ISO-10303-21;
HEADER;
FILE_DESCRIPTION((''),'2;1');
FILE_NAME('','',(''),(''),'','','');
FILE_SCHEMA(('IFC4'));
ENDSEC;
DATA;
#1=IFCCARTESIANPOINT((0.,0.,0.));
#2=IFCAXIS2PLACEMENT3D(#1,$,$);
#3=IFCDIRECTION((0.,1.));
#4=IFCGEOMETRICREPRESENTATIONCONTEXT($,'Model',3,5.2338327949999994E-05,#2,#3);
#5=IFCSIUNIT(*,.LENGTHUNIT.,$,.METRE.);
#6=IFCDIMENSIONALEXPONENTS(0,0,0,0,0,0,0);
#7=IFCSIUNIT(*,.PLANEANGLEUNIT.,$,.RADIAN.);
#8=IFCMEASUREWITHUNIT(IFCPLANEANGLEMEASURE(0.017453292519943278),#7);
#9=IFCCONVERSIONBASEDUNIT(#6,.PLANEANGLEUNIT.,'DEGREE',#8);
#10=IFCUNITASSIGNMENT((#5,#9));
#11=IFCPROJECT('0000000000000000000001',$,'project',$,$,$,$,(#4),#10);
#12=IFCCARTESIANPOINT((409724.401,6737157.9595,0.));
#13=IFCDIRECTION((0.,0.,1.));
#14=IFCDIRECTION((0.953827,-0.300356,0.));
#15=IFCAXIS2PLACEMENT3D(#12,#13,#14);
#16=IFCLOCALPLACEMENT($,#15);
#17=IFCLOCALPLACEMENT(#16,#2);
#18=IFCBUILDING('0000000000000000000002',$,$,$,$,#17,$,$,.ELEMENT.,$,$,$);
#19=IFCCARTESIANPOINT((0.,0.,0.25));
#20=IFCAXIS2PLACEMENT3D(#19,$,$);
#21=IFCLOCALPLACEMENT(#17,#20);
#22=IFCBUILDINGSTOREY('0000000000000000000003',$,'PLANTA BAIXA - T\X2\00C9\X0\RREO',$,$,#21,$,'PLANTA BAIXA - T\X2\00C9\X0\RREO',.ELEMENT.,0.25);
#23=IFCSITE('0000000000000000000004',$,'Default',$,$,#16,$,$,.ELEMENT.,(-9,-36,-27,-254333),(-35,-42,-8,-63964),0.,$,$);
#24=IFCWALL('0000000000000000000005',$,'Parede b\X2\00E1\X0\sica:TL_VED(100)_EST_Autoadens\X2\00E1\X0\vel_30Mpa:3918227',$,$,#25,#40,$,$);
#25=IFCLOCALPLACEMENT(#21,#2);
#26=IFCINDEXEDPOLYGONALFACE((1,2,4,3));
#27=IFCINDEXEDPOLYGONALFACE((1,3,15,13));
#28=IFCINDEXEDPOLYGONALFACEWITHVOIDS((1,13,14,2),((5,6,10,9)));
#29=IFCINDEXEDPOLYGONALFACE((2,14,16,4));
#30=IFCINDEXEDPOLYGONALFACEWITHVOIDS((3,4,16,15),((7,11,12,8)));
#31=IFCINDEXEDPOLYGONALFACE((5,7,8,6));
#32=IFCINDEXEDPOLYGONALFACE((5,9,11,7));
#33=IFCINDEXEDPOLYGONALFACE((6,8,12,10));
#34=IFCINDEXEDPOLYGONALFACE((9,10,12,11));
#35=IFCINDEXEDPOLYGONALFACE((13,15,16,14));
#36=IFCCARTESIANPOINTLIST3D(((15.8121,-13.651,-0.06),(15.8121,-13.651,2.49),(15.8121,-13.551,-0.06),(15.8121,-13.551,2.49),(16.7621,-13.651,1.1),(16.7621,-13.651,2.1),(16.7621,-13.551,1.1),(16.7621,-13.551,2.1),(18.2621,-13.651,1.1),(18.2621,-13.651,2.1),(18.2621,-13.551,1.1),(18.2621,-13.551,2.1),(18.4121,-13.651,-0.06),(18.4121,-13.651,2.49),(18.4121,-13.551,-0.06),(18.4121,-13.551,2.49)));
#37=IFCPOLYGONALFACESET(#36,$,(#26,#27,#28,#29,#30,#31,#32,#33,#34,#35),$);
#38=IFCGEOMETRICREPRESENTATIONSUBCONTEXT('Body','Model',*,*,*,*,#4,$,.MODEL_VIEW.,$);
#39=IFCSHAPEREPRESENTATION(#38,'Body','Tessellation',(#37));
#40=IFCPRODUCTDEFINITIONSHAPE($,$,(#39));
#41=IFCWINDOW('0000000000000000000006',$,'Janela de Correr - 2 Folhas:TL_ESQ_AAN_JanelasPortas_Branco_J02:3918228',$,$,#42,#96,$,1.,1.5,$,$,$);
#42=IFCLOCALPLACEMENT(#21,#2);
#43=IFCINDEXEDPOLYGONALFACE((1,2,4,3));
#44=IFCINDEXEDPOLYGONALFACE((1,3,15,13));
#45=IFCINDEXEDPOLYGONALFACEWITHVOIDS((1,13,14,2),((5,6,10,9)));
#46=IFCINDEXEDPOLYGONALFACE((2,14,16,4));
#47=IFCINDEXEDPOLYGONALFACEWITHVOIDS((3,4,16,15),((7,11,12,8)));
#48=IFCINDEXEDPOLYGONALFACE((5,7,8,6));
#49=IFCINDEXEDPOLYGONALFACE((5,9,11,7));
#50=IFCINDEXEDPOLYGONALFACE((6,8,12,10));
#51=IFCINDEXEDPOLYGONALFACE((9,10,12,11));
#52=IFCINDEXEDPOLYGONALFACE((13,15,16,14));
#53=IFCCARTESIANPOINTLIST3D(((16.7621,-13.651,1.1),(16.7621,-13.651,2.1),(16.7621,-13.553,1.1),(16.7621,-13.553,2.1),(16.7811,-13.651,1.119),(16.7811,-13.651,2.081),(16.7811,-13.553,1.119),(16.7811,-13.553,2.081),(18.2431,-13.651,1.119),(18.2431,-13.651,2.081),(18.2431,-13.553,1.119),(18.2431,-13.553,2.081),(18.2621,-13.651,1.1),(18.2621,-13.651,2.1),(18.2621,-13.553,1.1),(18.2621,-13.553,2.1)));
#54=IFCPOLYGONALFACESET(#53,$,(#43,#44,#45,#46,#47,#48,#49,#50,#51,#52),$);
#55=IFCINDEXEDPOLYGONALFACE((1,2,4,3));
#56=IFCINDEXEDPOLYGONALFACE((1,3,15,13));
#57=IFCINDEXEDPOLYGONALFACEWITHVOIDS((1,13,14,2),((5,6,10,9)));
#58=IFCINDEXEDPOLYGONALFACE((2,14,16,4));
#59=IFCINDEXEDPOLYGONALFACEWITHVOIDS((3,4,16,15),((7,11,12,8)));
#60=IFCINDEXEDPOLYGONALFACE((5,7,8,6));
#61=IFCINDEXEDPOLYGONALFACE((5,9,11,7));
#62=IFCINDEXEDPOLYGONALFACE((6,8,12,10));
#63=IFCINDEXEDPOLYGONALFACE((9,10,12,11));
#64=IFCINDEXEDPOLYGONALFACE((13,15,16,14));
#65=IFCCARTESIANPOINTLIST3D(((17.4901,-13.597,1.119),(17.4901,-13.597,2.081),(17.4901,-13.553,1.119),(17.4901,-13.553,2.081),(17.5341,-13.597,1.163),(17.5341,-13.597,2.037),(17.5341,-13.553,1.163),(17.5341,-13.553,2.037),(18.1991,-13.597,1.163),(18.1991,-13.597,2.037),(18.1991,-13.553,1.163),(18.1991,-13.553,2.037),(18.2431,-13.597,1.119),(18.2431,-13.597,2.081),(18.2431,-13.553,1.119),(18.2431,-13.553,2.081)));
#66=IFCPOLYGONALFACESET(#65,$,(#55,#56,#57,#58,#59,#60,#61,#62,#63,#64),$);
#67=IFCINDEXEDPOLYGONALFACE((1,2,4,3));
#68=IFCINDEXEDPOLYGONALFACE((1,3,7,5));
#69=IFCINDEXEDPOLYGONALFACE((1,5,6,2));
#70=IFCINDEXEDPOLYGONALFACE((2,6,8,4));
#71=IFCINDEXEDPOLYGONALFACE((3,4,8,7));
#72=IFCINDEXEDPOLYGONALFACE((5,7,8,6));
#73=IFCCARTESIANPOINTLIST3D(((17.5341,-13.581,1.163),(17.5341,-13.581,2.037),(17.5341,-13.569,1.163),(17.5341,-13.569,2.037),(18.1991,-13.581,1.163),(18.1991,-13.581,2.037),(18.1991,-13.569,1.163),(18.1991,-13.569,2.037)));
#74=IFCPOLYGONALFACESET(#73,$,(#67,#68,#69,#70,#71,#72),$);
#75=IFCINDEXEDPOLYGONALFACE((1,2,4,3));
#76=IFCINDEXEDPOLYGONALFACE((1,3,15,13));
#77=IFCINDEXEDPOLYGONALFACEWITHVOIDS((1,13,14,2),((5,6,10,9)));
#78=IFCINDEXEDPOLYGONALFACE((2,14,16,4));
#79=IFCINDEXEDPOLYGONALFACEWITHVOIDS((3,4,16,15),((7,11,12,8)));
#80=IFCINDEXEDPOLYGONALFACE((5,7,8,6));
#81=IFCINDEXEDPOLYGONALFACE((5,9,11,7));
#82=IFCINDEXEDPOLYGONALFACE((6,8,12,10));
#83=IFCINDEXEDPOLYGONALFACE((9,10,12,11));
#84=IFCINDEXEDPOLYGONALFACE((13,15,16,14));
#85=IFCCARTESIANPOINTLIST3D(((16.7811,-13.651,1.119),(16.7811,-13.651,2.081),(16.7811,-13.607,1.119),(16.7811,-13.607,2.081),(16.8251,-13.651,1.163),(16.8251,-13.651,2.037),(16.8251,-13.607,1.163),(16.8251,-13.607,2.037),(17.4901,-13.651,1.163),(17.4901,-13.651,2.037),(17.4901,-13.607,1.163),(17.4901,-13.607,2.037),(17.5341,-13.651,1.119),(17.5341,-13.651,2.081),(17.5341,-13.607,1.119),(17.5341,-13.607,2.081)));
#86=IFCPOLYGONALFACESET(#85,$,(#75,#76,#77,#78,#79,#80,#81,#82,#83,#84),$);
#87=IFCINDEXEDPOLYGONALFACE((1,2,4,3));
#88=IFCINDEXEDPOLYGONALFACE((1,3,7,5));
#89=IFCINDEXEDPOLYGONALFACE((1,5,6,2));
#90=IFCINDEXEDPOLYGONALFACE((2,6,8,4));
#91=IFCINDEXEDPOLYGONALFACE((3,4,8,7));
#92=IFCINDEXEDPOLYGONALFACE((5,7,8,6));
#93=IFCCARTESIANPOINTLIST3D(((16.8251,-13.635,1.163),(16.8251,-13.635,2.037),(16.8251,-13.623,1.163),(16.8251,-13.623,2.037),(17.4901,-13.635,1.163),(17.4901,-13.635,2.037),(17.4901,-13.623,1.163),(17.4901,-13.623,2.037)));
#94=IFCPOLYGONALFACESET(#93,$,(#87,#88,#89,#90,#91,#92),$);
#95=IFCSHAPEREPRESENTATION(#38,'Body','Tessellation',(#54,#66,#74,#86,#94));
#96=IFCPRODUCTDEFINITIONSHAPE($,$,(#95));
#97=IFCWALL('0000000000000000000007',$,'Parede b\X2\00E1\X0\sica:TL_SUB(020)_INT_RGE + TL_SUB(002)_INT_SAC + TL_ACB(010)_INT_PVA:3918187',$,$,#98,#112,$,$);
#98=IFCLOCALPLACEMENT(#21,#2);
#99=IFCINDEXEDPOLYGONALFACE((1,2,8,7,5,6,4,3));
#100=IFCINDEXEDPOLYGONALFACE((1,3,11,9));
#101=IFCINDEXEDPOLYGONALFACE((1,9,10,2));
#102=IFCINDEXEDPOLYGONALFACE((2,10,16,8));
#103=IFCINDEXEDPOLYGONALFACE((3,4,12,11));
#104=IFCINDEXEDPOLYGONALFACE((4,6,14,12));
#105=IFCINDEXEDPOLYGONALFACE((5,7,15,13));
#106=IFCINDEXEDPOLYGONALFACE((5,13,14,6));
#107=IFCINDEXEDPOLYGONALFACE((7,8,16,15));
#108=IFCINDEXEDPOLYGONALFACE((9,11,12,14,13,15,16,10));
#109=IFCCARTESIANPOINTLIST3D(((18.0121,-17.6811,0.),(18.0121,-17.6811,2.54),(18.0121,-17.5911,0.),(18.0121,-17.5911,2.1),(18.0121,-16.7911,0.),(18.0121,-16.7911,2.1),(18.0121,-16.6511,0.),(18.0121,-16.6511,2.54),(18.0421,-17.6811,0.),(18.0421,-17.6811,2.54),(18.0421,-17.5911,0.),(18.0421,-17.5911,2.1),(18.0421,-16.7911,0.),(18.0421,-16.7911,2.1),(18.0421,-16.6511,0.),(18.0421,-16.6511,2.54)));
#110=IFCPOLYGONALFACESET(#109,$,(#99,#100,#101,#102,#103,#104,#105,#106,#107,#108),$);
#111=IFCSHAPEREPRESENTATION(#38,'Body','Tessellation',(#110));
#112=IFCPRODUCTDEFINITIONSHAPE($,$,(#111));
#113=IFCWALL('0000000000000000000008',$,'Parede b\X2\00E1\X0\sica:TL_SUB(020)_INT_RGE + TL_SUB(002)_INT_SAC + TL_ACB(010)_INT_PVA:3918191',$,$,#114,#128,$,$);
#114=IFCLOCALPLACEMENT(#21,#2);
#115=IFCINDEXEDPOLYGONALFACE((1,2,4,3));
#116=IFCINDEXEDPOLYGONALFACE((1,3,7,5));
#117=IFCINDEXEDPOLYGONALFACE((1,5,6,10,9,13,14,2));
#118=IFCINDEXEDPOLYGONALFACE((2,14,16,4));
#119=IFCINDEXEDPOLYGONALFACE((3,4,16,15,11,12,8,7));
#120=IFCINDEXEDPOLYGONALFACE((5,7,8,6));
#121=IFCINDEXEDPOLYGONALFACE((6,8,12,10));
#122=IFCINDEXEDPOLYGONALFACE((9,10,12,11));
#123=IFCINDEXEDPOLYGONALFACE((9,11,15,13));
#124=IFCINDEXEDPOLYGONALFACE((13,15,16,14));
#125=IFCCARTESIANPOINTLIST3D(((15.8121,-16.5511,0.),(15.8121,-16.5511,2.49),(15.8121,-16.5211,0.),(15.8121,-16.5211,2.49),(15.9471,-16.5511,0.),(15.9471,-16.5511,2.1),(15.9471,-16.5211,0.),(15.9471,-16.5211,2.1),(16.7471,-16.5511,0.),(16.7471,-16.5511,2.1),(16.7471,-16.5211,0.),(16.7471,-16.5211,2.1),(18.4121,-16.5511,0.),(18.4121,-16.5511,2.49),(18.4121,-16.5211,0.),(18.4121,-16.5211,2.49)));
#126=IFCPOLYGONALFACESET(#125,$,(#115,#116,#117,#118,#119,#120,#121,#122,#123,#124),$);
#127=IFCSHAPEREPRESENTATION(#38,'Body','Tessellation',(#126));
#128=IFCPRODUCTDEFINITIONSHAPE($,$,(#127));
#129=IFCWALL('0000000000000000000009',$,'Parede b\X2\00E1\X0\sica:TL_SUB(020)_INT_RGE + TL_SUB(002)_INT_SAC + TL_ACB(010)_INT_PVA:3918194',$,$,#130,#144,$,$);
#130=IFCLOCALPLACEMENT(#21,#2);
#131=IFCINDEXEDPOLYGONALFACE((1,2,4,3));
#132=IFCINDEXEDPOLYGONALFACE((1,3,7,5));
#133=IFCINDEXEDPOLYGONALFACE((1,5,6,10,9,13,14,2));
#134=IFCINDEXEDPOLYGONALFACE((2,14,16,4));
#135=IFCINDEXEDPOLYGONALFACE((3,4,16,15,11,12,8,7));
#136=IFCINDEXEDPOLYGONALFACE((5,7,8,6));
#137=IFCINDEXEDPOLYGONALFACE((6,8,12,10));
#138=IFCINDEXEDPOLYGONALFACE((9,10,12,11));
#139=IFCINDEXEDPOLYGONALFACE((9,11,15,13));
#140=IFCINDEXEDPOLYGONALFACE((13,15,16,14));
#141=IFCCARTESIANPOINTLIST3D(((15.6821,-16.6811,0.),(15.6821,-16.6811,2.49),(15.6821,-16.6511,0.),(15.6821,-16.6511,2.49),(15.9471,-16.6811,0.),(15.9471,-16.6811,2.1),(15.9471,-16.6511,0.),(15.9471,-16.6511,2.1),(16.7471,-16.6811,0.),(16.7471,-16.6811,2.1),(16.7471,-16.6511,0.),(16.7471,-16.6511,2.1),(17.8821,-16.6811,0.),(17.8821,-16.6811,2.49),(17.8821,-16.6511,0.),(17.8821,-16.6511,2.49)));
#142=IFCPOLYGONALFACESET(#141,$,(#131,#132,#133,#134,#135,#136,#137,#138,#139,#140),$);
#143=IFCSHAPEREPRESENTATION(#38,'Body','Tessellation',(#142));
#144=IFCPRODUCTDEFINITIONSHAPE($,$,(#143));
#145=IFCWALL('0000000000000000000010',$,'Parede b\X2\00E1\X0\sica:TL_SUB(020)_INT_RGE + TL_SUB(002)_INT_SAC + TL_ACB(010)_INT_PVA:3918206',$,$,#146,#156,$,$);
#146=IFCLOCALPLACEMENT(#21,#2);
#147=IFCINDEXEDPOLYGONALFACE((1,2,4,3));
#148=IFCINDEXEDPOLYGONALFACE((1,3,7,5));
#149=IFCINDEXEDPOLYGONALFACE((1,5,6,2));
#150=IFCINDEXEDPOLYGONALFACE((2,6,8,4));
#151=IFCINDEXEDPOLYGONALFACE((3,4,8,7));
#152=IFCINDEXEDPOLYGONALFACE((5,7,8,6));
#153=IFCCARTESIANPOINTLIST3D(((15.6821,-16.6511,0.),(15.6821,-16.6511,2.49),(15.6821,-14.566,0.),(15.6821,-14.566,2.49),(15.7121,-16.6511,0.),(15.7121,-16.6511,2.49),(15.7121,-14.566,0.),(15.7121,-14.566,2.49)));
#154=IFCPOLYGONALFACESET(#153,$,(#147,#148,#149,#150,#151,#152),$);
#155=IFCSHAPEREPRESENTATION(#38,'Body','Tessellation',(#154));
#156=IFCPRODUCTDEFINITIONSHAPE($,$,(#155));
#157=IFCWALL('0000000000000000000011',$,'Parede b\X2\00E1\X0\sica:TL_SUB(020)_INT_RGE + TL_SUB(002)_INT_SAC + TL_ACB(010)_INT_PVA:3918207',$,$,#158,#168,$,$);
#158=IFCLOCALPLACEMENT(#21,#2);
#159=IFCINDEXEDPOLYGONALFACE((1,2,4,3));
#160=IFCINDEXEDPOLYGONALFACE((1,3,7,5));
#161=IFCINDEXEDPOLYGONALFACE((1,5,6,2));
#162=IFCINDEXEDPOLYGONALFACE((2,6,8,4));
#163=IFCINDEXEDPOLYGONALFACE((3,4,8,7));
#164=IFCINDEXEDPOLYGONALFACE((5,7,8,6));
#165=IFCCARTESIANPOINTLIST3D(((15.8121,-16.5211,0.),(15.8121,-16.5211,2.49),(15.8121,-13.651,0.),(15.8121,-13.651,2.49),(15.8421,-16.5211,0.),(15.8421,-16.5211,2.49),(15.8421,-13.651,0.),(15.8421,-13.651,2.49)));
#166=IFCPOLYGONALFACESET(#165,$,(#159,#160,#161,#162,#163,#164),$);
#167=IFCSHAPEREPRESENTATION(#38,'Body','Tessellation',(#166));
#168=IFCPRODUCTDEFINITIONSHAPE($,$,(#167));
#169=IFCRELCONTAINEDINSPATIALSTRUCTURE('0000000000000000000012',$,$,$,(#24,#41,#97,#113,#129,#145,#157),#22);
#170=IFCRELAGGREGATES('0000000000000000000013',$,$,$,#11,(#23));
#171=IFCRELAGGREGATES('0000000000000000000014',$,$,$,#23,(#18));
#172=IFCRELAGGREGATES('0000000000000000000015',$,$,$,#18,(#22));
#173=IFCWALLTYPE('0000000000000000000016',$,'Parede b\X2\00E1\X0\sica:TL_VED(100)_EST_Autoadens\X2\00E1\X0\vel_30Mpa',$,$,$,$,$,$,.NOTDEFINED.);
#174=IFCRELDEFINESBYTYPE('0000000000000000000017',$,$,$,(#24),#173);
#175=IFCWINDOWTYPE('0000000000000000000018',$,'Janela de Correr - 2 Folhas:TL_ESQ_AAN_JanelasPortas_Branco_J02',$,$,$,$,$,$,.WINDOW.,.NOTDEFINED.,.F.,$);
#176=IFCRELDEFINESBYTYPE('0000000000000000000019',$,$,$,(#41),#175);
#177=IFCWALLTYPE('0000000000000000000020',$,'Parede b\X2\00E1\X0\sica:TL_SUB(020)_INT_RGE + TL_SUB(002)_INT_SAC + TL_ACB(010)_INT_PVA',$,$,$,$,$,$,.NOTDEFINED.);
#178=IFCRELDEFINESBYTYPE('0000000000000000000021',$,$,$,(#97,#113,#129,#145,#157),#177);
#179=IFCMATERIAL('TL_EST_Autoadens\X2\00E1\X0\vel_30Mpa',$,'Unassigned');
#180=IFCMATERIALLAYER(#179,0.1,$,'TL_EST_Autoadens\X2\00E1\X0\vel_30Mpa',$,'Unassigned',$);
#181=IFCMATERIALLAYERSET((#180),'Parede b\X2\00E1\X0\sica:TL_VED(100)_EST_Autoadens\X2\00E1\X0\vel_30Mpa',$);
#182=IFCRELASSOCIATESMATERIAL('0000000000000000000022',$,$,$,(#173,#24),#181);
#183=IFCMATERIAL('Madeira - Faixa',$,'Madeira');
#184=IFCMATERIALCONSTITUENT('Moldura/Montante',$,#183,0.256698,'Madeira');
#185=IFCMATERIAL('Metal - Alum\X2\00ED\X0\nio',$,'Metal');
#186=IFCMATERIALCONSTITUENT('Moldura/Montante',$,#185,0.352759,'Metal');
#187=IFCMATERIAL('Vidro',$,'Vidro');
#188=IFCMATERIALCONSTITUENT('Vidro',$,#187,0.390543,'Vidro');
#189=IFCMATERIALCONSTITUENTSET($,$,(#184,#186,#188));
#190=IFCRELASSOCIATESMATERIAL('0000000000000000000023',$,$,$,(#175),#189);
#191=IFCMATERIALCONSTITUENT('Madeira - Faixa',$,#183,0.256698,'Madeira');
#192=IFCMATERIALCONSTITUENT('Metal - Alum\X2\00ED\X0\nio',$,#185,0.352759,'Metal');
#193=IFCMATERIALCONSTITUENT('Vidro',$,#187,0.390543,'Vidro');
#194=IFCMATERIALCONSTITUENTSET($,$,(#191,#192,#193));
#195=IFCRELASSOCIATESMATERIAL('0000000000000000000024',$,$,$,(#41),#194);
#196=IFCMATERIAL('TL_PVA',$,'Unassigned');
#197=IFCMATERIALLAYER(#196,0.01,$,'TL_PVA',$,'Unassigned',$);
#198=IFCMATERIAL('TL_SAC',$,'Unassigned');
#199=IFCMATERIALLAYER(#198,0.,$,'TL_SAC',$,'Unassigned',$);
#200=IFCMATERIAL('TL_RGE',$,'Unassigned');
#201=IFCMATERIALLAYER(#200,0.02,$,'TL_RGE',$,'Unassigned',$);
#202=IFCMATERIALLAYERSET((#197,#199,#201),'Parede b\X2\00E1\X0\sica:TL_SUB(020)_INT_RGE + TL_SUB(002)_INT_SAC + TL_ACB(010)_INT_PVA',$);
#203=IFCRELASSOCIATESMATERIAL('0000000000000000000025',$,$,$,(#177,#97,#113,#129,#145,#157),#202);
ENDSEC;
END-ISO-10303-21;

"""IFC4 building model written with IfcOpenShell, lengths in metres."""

from ifc_helpers import new_model, entity, si_unit, converted_unit, direction, frame, frame_2d, origin, origin_2d_with_axis, place, context, subcontext, project, spatial, polyline, rectangle, outline, extrude, source, transform, mapped, material, layer, layer_set, layer_usage, constituent, constituent_set, type_object, type_shapes, element, fill, save


model = new_model("IFC4")

# Units and contexts
model_context = context("Model", 3, precision=5.2338327949999994e-05, world=origin(), true_north=direction((0.0, 1.0)))
body_context = subcontext(model_context, "Body", "Model", "MODEL_VIEW")
ifc_project = project(units=[si_unit("LENGTHUNIT", "METRE"), converted_unit("PLANEANGLEUNIT", "DEGREE", entity("IfcPlaneAngleMeasure", 0.017453292519943278), si_unit("PLANEANGLEUNIT", "RADIAN"), dimensions=[0, 0, 0, 0, 0, 0, 0])], contexts=[model_context])

# Site, building, storey
site_placement = place(None, frame((409724.401, 6737157.9595, 0.0), z_axis=(0.0, 0.0, 1.0), x_axis=(0.953827, -0.300356, 0.0)))
site = spatial("IfcSite", under=ifc_project, at=site_placement, Name="Default", CompositionType="ELEMENT", RefLatitude=(-9, -36, -27, -254333), RefLongitude=(-35, -42, -8, -63964), RefElevation=0.0)
building_placement = place(site_placement, origin())
building = spatial("IfcBuilding", under=site, at=building_placement, CompositionType="ELEMENT")
storey_placement = place(building_placement, frame((0.0, 0.0, 0.25)))
storey = spatial("IfcBuildingStorey", under=building, at=storey_placement, Name="PLANTA BAIXA - TÉRREO", LongName="PLANTA BAIXA - TÉRREO", CompositionType="ELEMENT", Elevation=0.25)

# Shared definitions
ifc_material_1 = material(Name="TL_EST_Autoadensável_30Mpa", Category="Unassigned")
ifc_layer_1 = layer(ifc_material_1, 0.1, Name="TL_EST_Autoadensável_30Mpa", Category="Unassigned")
ifc_layer_set_1 = layer_set([ifc_layer_1], Name="Parede básica:TL_VED(100)_EST_Autoadensável_30Mpa")
wall_type_1 = type_object("IfcWallType", Name="Parede básica:TL_VED(100)_EST_Autoadensável_30Mpa", PredefinedType="NOTDEFINED", material=ifc_layer_set_1)

# Shared definitions
ifc_material_2 = material(Name="Vidro", Category="Vidro")

# Wall, opening, window
ifc_layer_usage_1 = layer_usage(ifc_layer_set_1, "AXIS2", "POSITIVE", -0.05)
wall_1_placement = place(storey_placement, frame((18.4121, -13.601, -0.06), z_axis=(0.0, 0.0, 1.0), x_axis=(-1.0, 0.0, 0.0)))
wall_1 = element("IfcWall", 1, at=wall_1_placement, inside=storey, type_object=wall_type_1, material=ifc_layer_usage_1, Name="Parede básica:TL_VED(100)_EST_Autoadensável_30Mpa:3918227", context=body_context, shape_type="SweptSolid", body=[
    extrude(rectangle(XDim=2.6, YDim=0.1, at=frame_2d((1.3, 0.0), x_axis=(-1.0, 0.0))), origin(), (0.0, 0.0, 1.0), 2.55),
])
opening_1_placement = place(wall_1_placement, frame((1.65, 0.05, 1.16)))
opening_1 = element("IfcOpeningElement", 2, at=opening_1_placement, cuts=wall_1, PredefinedType="OPENING", context=body_context, shape_type="SweptSolid", body=[
    extrude(rectangle(XDim=1.0, YDim=1.5, at=frame_2d((0.5, 0.75), x_axis=(-1.0, 0.0))), frame((0.0, 0.0, 0.0), z_axis=(0.0, -1.0, 0.0), x_axis=(0.0, 0.0, 1.0)), (0.0, 0.0, 1.0), 0.1),
])
ifc_material_3 = material(Name="Madeira - Faixa", Category="Madeira")
ifc_constituent_1 = constituent(ifc_material_3, Name="Madeira - Faixa", Category="Madeira", fraction=0.256698)
ifc_material_4 = material(Name="Metal - Alumínio", Category="Metal")
ifc_constituent_2 = constituent(ifc_material_4, Name="Metal - Alumínio", Category="Metal", fraction=0.352759)
ifc_constituent_3 = constituent(ifc_material_2, Name="Vidro", Category="Vidro", fraction=0.390543)
ifc_constituent_set_1 = constituent_set(constituents=[ifc_constituent_1, ifc_constituent_2, ifc_constituent_3])
ifc_constituent_4 = constituent(ifc_material_3, Name="Moldura/Montante", Category="Madeira", fraction=0.256698)
ifc_constituent_5 = constituent(ifc_material_4, Name="Moldura/Montante", Category="Metal", fraction=0.352759)
ifc_constituent_6 = constituent(ifc_material_2, Name="Vidro", Category="Vidro", fraction=0.390543)
ifc_constituent_set_2 = constituent_set(constituents=[ifc_constituent_4, ifc_constituent_5, ifc_constituent_6])
window_type = type_object("IfcWindowType", Name="Janela de Correr - 2 Folhas:TL_ESQ_AAN_JanelasPortas_Branco_J02", ParameterTakesPrecedence=False, PartitioningType="NOTDEFINED", PredefinedType="WINDOW", material=ifc_constituent_set_2)
shared_shape_1 = source(origin(), body_context, "Body", "SweptSolid", [
    extrude(outline(polyline([(-0.75, -0.5), (0.75, -0.5), (0.75, 0.5), (-0.75, 0.5), (-0.75, -0.5)]), holes=[polyline([(-0.731, -0.481), (-0.731, 0.481), (0.731, 0.481), (0.731, -0.481), (-0.731, -0.481)])]), frame((0.75, 0.0, 0.5), z_axis=(0.0, 1.0, 0.0), x_axis=(1.0, 0.0, 0.0)), (0.0, 0.0, 1.0), 0.098),
    extrude(outline(polyline([(-0.3765, -0.481), (0.3765, -0.481), (0.3765, 0.481), (-0.3765, 0.481), (-0.3765, -0.481)]), holes=[polyline([(-0.3325, -0.437), (-0.3325, 0.437), (0.3325, 0.437), (0.3325, -0.437), (-0.3325, -0.437)])]), frame((1.1045, 0.054, 0.5), z_axis=(0.0, 1.0, 0.0), x_axis=(1.0, 0.0, 0.0)), (0.0, 0.0, 1.0), 0.044),
    extrude(rectangle(XDim=0.012, YDim=0.665, at=origin_2d_with_axis()), frame((1.1045, 0.076, 0.063), z_axis=(0.0, 0.0, 1.0), x_axis=(0.0, -1.0, 0.0)), (0.0, 0.0, 1.0), 0.874),
    extrude(outline(polyline([(-0.481, -0.3765), (0.481, -0.3765), (0.481, 0.3765), (-0.481, 0.3765), (-0.481, -0.3765)]), holes=[polyline([(-0.437, -0.3325), (-0.437, 0.3325), (0.437, 0.3325), (0.437, -0.3325), (-0.437, -0.3325)])]), frame((0.3955, 0.0, 0.5), z_axis=(0.0, 1.0, 0.0), x_axis=(0.0, 0.0, -1.0)), (0.0, 0.0, 1.0), 0.044),
    extrude(rectangle(XDim=0.012, YDim=0.665, at=origin_2d_with_axis()), frame((0.3955, 0.022, 0.063), z_axis=(0.0, 0.0, 1.0), x_axis=(0.0, -1.0, 0.0)), (0.0, 0.0, 1.0), 0.874),
])
type_shapes(window_type, [shared_shape_1])
window_placement = place(opening_1_placement, frame((0.0, 0.0, 0.0), z_axis=(0.0, 0.0, 1.0), x_axis=(-1.0, 0.0, 0.0)))
window = element("IfcWindow", 3, at=window_placement, inside=storey, type_object=window_type, material=ifc_constituent_set_1, Name="Janela de Correr - 2 Folhas:TL_ESQ_AAN_JanelasPortas_Branco_J02:3918228", OverallHeight=1.0, OverallWidth=1.5, context=body_context, shape_type="MappedRepresentation", body=[
    mapped(shared_shape_1, transform((0.0, 0.0, 0.0), scale=1.0)),
])
fill(opening_1, window)

# Walls, openings
ifc_material_5 = material(Name="TL_PVA", Category="Unassigned")
ifc_layer_2 = layer(ifc_material_5, 0.01, Name="TL_PVA", Category="Unassigned")
ifc_material_6 = material(Name="TL_SAC", Category="Unassigned")
ifc_layer_3 = layer(ifc_material_6, 0.0, Name="TL_SAC", Category="Unassigned")
ifc_material_7 = material(Name="TL_RGE", Category="Unassigned")
ifc_layer_4 = layer(ifc_material_7, 0.02, Name="TL_RGE", Category="Unassigned")
ifc_layer_set_2 = layer_set([ifc_layer_2, ifc_layer_3, ifc_layer_4], Name="Parede básica:TL_SUB(020)_INT_RGE + TL_SUB(002)_INT_SAC + TL_ACB(010)_INT_PVA")
ifc_layer_usage_2 = layer_usage(ifc_layer_set_2, "AXIS2", "NEGATIVE", 0.015)
wall_type_2 = type_object("IfcWallType", Name="Parede básica:TL_SUB(020)_INT_RGE + TL_SUB(002)_INT_SAC + TL_ACB(010)_INT_PVA", PredefinedType="NOTDEFINED", material=ifc_layer_set_2)
wall_2_placement = place(storey_placement, frame((18.0271, -16.6511, 0.0), z_axis=(0.0, 0.0, 1.0), x_axis=(0.0, -1.0, 0.0)))
wall_2 = element("IfcWall", 4, at=wall_2_placement, inside=storey, type_object=wall_type_2, material=ifc_layer_usage_2, Name="Parede básica:TL_SUB(020)_INT_RGE + TL_SUB(002)_INT_SAC + TL_ACB(010)_INT_PVA:3918187", context=body_context, shape_type="SweptSolid", body=[
    extrude(rectangle(XDim=1.03, YDim=0.03, at=frame_2d((0.515, 0.0), x_axis=(-1.0, 0.0))), origin(), (0.0, 0.0, 1.0), 2.54),
])
opening_2_placement = place(wall_2_placement, frame((-16.6511, -18.0271, 0.0)))
element("IfcOpeningElement", 5, at=opening_2_placement, cuts=wall_2, PredefinedType="OPENING", context=body_context, shape_type="SweptSolid", body=[
    extrude(rectangle(XDim=2.1, YDim=0.8, at=frame_2d((0.0, 0.0), x_axis=(0.0, 1.0))), frame((17.1911, 16.3881, 1.05), z_axis=(0.0, 1.0, 0.0), x_axis=(-1.0, 0.0, 0.0)), (0.0, 0.0, 1.0), 3.048),
])
ifc_layer_usage_3 = layer_usage(ifc_layer_set_2, "AXIS2", "NEGATIVE", 0.015)
wall_3_placement = place(storey_placement, frame((15.8121, -16.5361, 0.0)))
wall_3 = element("IfcWall", 6, at=wall_3_placement, inside=storey, type_object=wall_type_2, material=ifc_layer_usage_3, Name="Parede básica:TL_SUB(020)_INT_RGE + TL_SUB(002)_INT_SAC + TL_ACB(010)_INT_PVA:3918191", context=body_context, shape_type="SweptSolid", body=[
    extrude(rectangle(XDim=2.6, YDim=0.03, at=frame_2d((1.3, 0.0), x_axis=(-1.0, 0.0))), origin(), (0.0, 0.0, 1.0), 2.49),
])
opening_3_placement = place(wall_3_placement, frame((-15.8121, 16.5361, 0.0)))
element("IfcOpeningElement", 7, at=opening_3_placement, cuts=wall_3, PredefinedType="OPENING", context=body_context, shape_type="SweptSolid", body=[
    extrude(rectangle(XDim=2.1, YDim=0.8, at=frame_2d((0.0, 0.0), x_axis=(1.0, 0.0))), frame((16.3471, -18.1751, 1.05), z_axis=(0.0, 1.0, 0.0), x_axis=(0.0, 0.0, 1.0)), (0.0, 0.0, 1.0), 3.048),
])
ifc_layer_usage_4 = layer_usage(ifc_layer_set_2, "AXIS2", "NEGATIVE", 0.015)
wall_4_placement = place(storey_placement, frame((17.8821, -16.6661, 0.0), z_axis=(0.0, 0.0, 1.0), x_axis=(-1.0, 0.0, 0.0)))
wall_4 = element("IfcWall", 8, at=wall_4_placement, inside=storey, type_object=wall_type_2, material=ifc_layer_usage_4, Name="Parede básica:TL_SUB(020)_INT_RGE + TL_SUB(002)_INT_SAC + TL_ACB(010)_INT_PVA:3918194", context=body_context, shape_type="SweptSolid", body=[
    extrude(rectangle(XDim=2.2, YDim=0.03, at=frame_2d((1.1, 0.0), x_axis=(-1.0, 0.0))), origin(), (0.0, 0.0, 1.0), 2.49),
])
opening_4_placement = place(wall_4_placement, frame((17.8821, -16.6661, 0.0)))
element("IfcOpeningElement", 9, at=opening_4_placement, cuts=wall_4, PredefinedType="OPENING", context=body_context, shape_type="SweptSolid", body=[
    extrude(rectangle(XDim=2.1, YDim=0.8, at=frame_2d((0.0, 0.0), x_axis=(0.0, 1.0))), frame((-16.3471, 15.1271, 1.05), z_axis=(0.0, 1.0, 0.0), x_axis=(-1.0, 0.0, 0.0)), (0.0, 0.0, 1.0), 3.048),
])

# Walls
ifc_layer_usage_5 = layer_usage(ifc_layer_set_2, "AXIS2", "POSITIVE", -0.015)
wall_5_placement = place(storey_placement, frame((15.6971, -14.566, 0.0), z_axis=(0.0, 0.0, 1.0), x_axis=(0.0, -1.0, 0.0)))
element("IfcWall", 10, at=wall_5_placement, inside=storey, type_object=wall_type_2, material=ifc_layer_usage_5, Name="Parede básica:TL_SUB(020)_INT_RGE + TL_SUB(002)_INT_SAC + TL_ACB(010)_INT_PVA:3918206", context=body_context, shape_type="SweptSolid", body=[
    extrude(rectangle(XDim=2.0851, YDim=0.03, at=frame_2d((1.0426, 0.0), x_axis=(-1.0, 0.0))), origin(), (0.0, 0.0, 1.0), 2.49),
])
ifc_layer_usage_6 = layer_usage(ifc_layer_set_2, "AXIS2", "POSITIVE", -0.015)
wall_6_placement = place(storey_placement, frame((15.8271, -16.5211, 0.0), z_axis=(0.0, 0.0, 1.0), x_axis=(0.0, 1.0, 0.0)))
element("IfcWall", 11, at=wall_6_placement, inside=storey, type_object=wall_type_2, material=ifc_layer_usage_6, Name="Parede básica:TL_SUB(020)_INT_RGE + TL_SUB(002)_INT_SAC + TL_ACB(010)_INT_PVA:3918207", context=body_context, shape_type="SweptSolid", body=[
    extrude(rectangle(XDim=2.8701, YDim=0.03, at=frame_2d((1.4351, 0.0), x_axis=(-1.0, 0.0))), origin(), (0.0, 0.0, 1.0), 2.49),
])

save(model, "model.ifc")
